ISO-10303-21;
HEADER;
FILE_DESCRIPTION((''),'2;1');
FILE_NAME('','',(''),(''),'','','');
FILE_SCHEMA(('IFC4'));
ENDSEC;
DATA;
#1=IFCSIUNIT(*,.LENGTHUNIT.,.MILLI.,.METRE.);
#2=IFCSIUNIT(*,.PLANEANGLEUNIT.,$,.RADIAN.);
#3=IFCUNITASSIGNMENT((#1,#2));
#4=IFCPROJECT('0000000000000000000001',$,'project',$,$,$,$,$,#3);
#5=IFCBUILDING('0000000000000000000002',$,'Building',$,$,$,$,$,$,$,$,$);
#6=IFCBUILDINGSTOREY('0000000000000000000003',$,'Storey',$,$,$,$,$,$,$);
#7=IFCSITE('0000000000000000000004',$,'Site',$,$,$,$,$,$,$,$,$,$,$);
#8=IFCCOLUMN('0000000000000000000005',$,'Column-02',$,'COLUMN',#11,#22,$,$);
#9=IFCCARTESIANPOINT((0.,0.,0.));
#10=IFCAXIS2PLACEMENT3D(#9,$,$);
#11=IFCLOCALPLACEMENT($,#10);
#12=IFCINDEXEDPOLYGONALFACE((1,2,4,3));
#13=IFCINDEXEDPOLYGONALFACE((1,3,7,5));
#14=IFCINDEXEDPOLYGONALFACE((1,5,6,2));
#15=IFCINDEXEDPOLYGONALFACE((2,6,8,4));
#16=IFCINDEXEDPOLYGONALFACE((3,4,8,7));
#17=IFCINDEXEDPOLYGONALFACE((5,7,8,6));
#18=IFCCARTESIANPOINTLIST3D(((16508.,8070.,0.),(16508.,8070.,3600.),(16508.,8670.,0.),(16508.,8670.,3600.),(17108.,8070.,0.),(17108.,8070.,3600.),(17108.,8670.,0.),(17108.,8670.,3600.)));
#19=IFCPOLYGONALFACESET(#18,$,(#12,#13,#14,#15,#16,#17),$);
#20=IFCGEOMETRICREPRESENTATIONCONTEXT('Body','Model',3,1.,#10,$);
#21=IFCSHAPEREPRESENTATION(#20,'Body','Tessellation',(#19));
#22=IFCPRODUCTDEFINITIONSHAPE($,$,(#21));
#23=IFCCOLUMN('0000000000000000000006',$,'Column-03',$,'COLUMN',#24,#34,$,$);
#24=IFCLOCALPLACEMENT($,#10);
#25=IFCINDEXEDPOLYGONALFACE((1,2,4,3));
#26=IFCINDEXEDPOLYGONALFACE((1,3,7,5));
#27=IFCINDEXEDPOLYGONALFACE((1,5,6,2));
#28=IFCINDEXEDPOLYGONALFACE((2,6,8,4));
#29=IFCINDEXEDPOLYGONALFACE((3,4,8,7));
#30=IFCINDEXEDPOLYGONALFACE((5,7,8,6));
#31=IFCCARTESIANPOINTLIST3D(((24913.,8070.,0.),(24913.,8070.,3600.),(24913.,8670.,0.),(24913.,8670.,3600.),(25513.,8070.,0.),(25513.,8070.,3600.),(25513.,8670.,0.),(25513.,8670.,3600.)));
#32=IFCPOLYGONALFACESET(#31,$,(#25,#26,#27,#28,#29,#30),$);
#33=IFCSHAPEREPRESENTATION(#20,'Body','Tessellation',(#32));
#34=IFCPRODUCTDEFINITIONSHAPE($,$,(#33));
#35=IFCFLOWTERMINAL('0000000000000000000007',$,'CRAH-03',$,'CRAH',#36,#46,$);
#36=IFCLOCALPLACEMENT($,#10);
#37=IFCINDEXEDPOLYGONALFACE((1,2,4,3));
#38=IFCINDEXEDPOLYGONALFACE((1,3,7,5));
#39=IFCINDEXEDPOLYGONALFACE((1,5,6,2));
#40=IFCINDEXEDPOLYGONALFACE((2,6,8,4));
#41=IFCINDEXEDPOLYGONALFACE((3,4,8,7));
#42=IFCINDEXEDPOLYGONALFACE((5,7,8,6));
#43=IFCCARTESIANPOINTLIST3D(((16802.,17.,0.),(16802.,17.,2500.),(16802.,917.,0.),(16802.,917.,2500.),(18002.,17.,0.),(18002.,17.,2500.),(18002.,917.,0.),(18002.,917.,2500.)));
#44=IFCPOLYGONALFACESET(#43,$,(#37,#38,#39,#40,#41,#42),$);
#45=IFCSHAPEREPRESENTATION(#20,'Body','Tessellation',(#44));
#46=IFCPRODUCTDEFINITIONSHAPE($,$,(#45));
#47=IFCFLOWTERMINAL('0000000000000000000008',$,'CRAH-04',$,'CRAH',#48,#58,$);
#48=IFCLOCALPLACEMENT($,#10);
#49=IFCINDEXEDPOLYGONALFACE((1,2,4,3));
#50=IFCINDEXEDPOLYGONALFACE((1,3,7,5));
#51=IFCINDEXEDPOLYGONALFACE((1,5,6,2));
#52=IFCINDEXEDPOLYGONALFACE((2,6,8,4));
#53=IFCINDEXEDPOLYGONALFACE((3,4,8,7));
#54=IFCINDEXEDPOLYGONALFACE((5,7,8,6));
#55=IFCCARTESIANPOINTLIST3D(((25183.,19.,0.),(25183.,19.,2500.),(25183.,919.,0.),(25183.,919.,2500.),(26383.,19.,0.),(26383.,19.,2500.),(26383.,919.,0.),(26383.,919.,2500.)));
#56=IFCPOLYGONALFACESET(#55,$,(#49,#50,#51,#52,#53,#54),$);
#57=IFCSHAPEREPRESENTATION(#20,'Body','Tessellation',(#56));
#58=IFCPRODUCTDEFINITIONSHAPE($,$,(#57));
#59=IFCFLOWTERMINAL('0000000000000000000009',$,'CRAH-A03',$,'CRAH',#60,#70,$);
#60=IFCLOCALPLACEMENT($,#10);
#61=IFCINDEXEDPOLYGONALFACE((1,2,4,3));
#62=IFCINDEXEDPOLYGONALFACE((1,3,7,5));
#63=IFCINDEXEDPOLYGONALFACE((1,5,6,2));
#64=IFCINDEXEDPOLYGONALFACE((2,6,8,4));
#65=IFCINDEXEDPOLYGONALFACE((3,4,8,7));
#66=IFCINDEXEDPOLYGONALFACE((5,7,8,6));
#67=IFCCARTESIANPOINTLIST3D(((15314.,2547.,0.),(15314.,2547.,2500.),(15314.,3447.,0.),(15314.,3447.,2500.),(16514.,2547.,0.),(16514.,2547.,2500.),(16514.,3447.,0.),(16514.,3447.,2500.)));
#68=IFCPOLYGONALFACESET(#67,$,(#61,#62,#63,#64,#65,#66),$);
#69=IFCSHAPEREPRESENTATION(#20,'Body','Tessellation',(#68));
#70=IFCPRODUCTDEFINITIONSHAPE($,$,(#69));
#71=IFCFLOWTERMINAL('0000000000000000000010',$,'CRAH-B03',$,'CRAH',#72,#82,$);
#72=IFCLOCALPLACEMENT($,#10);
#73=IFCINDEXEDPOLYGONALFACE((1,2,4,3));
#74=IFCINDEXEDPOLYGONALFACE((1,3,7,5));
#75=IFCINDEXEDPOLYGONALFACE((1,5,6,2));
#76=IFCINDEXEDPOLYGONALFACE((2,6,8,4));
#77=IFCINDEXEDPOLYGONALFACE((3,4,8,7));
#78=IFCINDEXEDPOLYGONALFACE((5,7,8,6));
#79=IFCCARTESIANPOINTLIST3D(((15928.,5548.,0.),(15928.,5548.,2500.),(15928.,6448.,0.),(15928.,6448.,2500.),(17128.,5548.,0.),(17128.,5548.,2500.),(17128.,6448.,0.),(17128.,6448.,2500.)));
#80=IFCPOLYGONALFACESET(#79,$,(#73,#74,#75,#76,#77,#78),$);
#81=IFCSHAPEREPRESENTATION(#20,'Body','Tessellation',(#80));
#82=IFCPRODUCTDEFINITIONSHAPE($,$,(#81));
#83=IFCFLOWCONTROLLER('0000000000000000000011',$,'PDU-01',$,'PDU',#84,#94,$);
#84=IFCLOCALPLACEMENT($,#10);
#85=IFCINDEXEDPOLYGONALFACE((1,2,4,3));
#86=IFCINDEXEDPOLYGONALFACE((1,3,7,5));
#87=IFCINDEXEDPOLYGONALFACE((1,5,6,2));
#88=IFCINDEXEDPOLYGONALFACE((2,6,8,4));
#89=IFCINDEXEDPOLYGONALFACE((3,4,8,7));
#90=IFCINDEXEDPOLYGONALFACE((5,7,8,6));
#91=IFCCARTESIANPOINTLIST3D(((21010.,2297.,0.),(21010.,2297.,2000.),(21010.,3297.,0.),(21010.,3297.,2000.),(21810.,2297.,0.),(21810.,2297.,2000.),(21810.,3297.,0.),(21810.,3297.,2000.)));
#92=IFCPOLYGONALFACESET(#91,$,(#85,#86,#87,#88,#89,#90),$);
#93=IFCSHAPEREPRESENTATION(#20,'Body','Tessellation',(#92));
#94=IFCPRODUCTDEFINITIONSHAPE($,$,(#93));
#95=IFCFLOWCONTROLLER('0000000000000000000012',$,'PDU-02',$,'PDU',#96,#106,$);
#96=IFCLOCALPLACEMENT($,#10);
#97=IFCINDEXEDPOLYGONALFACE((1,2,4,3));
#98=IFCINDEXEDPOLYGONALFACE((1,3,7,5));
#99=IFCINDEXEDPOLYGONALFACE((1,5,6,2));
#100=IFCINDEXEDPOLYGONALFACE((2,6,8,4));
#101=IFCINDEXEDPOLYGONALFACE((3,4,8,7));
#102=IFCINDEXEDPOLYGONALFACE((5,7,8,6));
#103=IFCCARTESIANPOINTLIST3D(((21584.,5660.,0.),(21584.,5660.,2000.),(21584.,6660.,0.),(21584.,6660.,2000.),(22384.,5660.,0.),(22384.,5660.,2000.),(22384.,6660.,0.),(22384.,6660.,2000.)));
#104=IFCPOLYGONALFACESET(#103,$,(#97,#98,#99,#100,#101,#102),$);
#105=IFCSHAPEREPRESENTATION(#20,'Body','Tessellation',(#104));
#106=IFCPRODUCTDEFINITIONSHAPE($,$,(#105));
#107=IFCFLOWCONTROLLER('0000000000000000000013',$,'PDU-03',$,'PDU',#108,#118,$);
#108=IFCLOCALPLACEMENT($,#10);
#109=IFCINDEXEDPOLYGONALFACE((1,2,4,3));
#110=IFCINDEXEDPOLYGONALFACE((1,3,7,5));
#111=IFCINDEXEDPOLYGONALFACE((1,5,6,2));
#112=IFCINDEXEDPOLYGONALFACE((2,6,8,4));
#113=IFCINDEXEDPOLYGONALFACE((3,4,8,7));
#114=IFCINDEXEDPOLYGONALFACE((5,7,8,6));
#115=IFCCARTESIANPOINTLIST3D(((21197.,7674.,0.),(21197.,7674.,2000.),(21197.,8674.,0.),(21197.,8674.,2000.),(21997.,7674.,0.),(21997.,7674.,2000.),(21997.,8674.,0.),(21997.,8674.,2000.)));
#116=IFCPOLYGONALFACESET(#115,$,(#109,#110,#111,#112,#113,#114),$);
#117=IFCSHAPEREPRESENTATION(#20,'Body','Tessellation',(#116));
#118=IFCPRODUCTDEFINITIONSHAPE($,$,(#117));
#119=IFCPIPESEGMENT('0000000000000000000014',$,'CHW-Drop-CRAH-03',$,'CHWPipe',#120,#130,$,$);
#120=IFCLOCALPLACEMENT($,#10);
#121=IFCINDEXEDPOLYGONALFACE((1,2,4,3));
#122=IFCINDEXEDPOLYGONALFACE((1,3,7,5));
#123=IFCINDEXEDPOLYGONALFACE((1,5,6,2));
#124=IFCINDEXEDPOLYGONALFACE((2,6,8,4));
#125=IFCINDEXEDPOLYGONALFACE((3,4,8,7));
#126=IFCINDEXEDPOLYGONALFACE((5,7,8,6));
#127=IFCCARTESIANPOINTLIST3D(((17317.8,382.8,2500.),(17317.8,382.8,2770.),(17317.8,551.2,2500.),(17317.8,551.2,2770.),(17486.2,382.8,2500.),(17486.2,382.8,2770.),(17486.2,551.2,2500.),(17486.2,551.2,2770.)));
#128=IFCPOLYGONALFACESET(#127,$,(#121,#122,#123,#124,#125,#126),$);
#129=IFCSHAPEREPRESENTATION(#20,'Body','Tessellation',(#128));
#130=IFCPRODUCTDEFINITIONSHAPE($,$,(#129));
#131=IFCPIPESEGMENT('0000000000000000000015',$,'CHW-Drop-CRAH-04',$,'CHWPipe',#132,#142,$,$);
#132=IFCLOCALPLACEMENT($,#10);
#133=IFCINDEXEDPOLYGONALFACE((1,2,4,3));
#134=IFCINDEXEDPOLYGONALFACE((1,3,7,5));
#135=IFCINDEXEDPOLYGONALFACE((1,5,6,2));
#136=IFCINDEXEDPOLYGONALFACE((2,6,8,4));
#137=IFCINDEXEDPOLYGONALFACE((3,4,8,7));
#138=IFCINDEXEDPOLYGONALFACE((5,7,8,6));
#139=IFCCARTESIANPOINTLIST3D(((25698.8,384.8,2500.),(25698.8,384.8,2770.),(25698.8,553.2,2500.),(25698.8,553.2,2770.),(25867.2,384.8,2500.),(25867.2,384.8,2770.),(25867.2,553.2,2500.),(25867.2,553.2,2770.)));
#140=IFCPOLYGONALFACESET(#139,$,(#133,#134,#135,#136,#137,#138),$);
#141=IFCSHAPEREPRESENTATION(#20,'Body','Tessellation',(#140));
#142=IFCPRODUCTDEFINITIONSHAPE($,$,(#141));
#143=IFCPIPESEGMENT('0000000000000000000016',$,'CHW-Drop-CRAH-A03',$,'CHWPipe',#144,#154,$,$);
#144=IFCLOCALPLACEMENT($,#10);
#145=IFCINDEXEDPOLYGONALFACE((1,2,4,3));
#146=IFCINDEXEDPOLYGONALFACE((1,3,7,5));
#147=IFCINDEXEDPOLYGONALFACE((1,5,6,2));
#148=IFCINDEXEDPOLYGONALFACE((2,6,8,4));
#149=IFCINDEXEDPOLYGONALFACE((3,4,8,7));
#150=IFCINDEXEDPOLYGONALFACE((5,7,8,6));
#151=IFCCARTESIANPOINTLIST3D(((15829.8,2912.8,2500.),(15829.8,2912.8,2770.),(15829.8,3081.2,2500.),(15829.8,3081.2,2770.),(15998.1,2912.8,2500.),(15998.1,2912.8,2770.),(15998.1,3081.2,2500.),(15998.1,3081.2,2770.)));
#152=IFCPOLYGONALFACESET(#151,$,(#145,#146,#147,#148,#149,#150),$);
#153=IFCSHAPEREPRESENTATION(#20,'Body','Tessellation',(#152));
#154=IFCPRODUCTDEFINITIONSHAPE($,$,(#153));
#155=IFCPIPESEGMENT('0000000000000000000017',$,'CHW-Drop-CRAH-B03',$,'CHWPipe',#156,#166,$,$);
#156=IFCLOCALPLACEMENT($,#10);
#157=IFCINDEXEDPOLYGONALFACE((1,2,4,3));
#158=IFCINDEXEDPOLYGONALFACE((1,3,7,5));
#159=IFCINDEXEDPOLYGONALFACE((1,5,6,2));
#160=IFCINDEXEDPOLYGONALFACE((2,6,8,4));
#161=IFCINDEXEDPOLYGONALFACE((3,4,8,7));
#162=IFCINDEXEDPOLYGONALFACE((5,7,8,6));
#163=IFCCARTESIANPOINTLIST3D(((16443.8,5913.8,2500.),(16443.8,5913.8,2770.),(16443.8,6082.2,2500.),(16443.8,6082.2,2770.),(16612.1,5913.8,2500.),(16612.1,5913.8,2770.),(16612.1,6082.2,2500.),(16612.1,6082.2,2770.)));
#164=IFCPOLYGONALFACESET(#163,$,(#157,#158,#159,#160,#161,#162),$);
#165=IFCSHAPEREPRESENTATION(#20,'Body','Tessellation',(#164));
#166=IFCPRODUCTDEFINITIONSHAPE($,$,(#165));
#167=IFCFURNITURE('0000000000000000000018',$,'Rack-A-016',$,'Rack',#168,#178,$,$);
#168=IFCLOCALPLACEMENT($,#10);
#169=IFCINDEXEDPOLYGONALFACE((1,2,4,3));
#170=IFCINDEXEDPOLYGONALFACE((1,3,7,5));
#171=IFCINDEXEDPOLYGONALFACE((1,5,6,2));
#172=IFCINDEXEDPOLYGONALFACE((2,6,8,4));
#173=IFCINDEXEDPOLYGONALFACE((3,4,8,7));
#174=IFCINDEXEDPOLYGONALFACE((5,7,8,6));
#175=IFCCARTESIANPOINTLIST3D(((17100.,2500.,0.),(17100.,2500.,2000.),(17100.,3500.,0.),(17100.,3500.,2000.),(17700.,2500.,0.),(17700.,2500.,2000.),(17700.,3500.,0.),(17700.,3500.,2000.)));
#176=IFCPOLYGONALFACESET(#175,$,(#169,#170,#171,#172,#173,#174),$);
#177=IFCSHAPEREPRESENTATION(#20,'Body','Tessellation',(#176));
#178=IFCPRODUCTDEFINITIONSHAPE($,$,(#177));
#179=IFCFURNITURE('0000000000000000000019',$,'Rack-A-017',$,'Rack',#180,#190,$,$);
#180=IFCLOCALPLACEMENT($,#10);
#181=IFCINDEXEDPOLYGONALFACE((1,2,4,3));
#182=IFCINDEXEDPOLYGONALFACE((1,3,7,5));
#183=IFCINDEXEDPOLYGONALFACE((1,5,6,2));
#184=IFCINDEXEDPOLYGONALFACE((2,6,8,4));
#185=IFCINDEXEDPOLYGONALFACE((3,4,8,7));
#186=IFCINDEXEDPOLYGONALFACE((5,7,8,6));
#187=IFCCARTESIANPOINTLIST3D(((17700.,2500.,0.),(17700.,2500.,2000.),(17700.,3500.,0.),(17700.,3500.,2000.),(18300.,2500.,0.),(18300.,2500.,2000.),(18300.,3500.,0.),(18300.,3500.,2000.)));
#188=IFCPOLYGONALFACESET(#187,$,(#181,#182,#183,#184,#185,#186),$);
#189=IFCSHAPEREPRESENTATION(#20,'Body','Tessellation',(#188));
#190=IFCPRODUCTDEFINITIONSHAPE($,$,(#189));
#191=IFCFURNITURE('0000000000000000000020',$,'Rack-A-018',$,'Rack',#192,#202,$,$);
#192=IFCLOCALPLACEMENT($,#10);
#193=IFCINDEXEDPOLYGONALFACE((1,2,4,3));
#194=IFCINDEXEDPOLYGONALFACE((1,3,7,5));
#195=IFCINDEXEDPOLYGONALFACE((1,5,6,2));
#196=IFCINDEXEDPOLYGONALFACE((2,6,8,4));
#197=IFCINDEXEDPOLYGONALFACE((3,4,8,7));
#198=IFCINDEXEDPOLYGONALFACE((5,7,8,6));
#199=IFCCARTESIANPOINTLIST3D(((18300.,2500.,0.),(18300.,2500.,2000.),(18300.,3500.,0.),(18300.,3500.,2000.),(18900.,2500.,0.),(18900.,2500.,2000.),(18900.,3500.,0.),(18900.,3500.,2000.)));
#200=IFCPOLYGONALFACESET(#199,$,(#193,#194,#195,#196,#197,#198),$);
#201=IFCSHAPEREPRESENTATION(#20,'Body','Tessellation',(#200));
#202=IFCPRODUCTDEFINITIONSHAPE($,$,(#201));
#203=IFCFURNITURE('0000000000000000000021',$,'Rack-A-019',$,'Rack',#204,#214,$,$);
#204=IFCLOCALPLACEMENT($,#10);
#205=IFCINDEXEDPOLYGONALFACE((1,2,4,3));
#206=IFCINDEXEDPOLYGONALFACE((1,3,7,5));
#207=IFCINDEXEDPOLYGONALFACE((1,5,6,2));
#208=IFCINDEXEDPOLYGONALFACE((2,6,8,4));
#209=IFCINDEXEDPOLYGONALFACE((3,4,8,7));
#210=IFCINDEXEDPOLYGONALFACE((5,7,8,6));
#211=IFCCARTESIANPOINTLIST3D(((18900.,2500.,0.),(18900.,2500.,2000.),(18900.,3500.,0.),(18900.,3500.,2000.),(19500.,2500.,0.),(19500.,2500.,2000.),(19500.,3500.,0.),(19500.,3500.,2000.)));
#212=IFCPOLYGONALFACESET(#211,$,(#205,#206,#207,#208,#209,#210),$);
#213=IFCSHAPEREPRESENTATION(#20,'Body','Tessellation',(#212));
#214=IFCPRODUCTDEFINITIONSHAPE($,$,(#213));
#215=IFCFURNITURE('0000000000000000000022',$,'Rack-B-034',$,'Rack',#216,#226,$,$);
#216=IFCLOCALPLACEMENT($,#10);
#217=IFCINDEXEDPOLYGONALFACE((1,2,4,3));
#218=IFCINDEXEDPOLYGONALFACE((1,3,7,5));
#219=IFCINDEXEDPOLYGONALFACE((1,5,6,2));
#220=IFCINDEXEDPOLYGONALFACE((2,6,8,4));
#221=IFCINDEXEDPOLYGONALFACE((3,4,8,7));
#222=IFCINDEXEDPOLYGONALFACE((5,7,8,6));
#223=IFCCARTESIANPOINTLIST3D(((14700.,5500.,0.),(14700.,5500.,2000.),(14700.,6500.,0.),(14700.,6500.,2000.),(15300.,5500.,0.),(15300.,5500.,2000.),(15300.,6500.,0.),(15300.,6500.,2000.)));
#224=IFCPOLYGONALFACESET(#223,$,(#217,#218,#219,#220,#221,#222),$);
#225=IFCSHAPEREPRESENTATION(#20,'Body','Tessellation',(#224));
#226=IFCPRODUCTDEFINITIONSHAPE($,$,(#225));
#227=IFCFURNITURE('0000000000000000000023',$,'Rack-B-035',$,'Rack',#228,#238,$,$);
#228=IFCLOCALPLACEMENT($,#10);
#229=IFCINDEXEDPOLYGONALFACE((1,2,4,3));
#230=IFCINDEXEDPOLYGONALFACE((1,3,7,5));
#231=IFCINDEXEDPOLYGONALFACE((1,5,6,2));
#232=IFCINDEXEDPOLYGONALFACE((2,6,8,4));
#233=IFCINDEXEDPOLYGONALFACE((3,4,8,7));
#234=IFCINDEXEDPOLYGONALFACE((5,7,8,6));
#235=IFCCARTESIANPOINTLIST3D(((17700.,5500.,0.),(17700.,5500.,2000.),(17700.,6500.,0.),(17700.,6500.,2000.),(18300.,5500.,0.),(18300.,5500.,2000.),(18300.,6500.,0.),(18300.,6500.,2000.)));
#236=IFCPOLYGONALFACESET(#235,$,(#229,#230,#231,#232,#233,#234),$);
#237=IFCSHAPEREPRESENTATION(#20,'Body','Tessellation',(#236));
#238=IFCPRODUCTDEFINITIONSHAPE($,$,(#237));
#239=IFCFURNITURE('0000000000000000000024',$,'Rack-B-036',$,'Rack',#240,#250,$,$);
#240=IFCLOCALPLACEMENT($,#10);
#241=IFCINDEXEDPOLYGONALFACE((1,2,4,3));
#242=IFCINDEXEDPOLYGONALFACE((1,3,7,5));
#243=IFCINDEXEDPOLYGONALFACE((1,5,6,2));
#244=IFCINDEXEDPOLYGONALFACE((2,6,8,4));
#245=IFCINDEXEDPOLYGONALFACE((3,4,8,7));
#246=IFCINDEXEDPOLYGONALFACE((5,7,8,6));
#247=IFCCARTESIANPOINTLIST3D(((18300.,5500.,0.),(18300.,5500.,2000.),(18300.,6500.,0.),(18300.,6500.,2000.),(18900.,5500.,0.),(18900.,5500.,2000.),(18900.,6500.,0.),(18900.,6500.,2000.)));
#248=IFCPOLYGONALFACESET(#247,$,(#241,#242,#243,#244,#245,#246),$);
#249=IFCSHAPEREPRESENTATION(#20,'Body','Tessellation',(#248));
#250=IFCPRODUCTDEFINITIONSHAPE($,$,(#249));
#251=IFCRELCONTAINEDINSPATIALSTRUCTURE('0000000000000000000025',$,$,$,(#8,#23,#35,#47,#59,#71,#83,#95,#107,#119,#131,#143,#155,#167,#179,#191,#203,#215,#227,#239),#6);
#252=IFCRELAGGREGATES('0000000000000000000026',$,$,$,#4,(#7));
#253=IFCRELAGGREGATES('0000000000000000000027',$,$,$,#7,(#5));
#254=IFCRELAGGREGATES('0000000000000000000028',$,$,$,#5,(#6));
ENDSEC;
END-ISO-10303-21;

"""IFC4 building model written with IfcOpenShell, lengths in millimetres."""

from ifc_helpers import new_model, si_unit, frame, origin, place, context, project, spatial, rectangle, extrude, element, save


model = new_model("IFC4")

# Units and contexts
model_context = context("Model", 3, precision=1.0, world=origin(), identifier="Body")
ifc_project = project(units=[si_unit("LENGTHUNIT", "METRE", prefix="MILLI"), si_unit("PLANEANGLEUNIT", "RADIAN")])

# Site, building, storey
site = spatial("IfcSite", under=ifc_project, Name="Site")
building = spatial("IfcBuilding", under=site, Name="Building")
storey = spatial("IfcBuildingStorey", under=building, Name="Storey")

# Columns
for number, where, z_axis, x_axis, name in (
    (1, (16808.0, 8370.0, 0.0), (0.0, 0.0, 1.0), (1.0, 0.0, 0.0), "Column-02"),
    (2, (25213.0, 8370.0, 0.0), (0.0, 0.0, 1.0), (1.0, 0.0, 0.0), "Column-03"),
):
    element("IfcColumn", number, at=place(None, frame(where, z_axis=z_axis, x_axis=x_axis)), inside=storey, Name=name, ObjectType="COLUMN", context=model_context, shape_type="SweptSolid", body=[
        extrude(rectangle(XDim=600.0, YDim=600.0), origin(), (0.0, 0.0, 1.0), 3600.0),
    ])

# Flow terminals
for number, where, z_axis, x_axis, name in (
    (3, (17402.0, 467.0, 0.0), (0.0, 0.0, 1.0), (1.0, 0.0, 0.0), "CRAH-03"),
    (4, (25783.0, 469.0, 0.0), (0.0, 0.0, 1.0), (1.0, 0.0, 0.0), "CRAH-04"),
    (5, (15914.0, 2997.0, 0.0), (0.0, 0.0, 1.0), (1.0, 0.0, 0.0), "CRAH-A03"),
    (6, (16528.0, 5998.0, 0.0), (0.0, 0.0, 1.0), (1.0, 0.0, 0.0), "CRAH-B03"),
):
    element("IfcFlowTerminal", number, at=place(None, frame(where, z_axis=z_axis, x_axis=x_axis)), inside=storey, Name=name, ObjectType="CRAH", context=model_context, shape_type="SweptSolid", body=[
        extrude(rectangle(XDim=1200.0, YDim=900.0), origin(), (0.0, 0.0, 1.0), 2500.0),
    ])

# Flow controllers
for number, where, z_axis, x_axis, name in (
    (7, (21410.0, 2797.0, 0.0), (0.0, 0.0, 1.0), (1.0, 0.0, 0.0), "PDU-01"),
    (8, (21984.0, 6160.0, 0.0), (0.0, 0.0, 1.0), (1.0, 0.0, 0.0), "PDU-02"),
    (9, (21597.0, 8174.0, 0.0), (0.0, 0.0, 1.0), (1.0, 0.0, 0.0), "PDU-03"),
):
    element("IfcFlowController", number, at=place(None, frame(where, z_axis=z_axis, x_axis=x_axis)), inside=storey, Name=name, ObjectType="PDU", context=model_context, shape_type="SweptSolid", body=[
        extrude(rectangle(XDim=800.0, YDim=1000.0), origin(), (0.0, 0.0, 1.0), 2000.0),
    ])

# Pipe segments
for number, where, z_axis, x_axis, name in (
    (10, (17402.0, 467.0, 2500.0), (0.0, 0.0, 1.0), (1.0, 0.0, 0.0), "CHW-Drop-CRAH-03"),
    (11, (25783.0, 469.0, 2500.0), (0.0, 0.0, 1.0), (1.0, 0.0, 0.0), "CHW-Drop-CRAH-04"),
    (12, (15914.0, 2997.0, 2500.0), (0.0, 0.0, 1.0), (1.0, 0.0, 0.0), "CHW-Drop-CRAH-A03"),
    (13, (16528.0, 5998.0, 2500.0), (0.0, 0.0, 1.0), (1.0, 0.0, 0.0), "CHW-Drop-CRAH-B03"),
):
    element("IfcPipeSegment", number, at=place(None, frame(where, z_axis=z_axis, x_axis=x_axis)), inside=storey, Name=name, ObjectType="CHWPipe", context=model_context, shape_type="SweptSolid", body=[
        extrude(rectangle(XDim=168.3, YDim=168.3), origin(), (0.0, 0.0, 1.0), 270.0),
    ])

# Furniture
for number, where, z_axis, x_axis, name in (
    (14, (17400.0, 3000.0, 0.0), (0.0, 0.0, 1.0), (1.0, 0.0, 0.0), "Rack-A-016"),
    (15, (18000.0, 3000.0, 0.0), (0.0, 0.0, 1.0), (1.0, 0.0, 0.0), "Rack-A-017"),
    (16, (18600.0, 3000.0, 0.0), (0.0, 0.0, 1.0), (1.0, 0.0, 0.0), "Rack-A-018"),
    (17, (19200.0, 3000.0, 0.0), (0.0, 0.0, 1.0), (1.0, 0.0, 0.0), "Rack-A-019"),
    (18, (15000.0, 6000.0, 0.0), (0.0, 0.0, 1.0), (1.0, 0.0, 0.0), "Rack-B-034"),
    (19, (18000.0, 6000.0, 0.0), (0.0, 0.0, 1.0), (1.0, 0.0, 0.0), "Rack-B-035"),
    (20, (18600.0, 6000.0, 0.0), (0.0, 0.0, 1.0), (1.0, 0.0, 0.0), "Rack-B-036"),
):
    element("IfcFurniture", number, at=place(None, frame(where, z_axis=z_axis, x_axis=x_axis)), inside=storey, Name=name, ObjectType="Rack", context=model_context, shape_type="SweptSolid", body=[
        extrude(rectangle(XDim=600.0, YDim=1000.0), origin(), (0.0, 0.0, 1.0), 2000.0),
    ])

save(model, "model.ifc")
